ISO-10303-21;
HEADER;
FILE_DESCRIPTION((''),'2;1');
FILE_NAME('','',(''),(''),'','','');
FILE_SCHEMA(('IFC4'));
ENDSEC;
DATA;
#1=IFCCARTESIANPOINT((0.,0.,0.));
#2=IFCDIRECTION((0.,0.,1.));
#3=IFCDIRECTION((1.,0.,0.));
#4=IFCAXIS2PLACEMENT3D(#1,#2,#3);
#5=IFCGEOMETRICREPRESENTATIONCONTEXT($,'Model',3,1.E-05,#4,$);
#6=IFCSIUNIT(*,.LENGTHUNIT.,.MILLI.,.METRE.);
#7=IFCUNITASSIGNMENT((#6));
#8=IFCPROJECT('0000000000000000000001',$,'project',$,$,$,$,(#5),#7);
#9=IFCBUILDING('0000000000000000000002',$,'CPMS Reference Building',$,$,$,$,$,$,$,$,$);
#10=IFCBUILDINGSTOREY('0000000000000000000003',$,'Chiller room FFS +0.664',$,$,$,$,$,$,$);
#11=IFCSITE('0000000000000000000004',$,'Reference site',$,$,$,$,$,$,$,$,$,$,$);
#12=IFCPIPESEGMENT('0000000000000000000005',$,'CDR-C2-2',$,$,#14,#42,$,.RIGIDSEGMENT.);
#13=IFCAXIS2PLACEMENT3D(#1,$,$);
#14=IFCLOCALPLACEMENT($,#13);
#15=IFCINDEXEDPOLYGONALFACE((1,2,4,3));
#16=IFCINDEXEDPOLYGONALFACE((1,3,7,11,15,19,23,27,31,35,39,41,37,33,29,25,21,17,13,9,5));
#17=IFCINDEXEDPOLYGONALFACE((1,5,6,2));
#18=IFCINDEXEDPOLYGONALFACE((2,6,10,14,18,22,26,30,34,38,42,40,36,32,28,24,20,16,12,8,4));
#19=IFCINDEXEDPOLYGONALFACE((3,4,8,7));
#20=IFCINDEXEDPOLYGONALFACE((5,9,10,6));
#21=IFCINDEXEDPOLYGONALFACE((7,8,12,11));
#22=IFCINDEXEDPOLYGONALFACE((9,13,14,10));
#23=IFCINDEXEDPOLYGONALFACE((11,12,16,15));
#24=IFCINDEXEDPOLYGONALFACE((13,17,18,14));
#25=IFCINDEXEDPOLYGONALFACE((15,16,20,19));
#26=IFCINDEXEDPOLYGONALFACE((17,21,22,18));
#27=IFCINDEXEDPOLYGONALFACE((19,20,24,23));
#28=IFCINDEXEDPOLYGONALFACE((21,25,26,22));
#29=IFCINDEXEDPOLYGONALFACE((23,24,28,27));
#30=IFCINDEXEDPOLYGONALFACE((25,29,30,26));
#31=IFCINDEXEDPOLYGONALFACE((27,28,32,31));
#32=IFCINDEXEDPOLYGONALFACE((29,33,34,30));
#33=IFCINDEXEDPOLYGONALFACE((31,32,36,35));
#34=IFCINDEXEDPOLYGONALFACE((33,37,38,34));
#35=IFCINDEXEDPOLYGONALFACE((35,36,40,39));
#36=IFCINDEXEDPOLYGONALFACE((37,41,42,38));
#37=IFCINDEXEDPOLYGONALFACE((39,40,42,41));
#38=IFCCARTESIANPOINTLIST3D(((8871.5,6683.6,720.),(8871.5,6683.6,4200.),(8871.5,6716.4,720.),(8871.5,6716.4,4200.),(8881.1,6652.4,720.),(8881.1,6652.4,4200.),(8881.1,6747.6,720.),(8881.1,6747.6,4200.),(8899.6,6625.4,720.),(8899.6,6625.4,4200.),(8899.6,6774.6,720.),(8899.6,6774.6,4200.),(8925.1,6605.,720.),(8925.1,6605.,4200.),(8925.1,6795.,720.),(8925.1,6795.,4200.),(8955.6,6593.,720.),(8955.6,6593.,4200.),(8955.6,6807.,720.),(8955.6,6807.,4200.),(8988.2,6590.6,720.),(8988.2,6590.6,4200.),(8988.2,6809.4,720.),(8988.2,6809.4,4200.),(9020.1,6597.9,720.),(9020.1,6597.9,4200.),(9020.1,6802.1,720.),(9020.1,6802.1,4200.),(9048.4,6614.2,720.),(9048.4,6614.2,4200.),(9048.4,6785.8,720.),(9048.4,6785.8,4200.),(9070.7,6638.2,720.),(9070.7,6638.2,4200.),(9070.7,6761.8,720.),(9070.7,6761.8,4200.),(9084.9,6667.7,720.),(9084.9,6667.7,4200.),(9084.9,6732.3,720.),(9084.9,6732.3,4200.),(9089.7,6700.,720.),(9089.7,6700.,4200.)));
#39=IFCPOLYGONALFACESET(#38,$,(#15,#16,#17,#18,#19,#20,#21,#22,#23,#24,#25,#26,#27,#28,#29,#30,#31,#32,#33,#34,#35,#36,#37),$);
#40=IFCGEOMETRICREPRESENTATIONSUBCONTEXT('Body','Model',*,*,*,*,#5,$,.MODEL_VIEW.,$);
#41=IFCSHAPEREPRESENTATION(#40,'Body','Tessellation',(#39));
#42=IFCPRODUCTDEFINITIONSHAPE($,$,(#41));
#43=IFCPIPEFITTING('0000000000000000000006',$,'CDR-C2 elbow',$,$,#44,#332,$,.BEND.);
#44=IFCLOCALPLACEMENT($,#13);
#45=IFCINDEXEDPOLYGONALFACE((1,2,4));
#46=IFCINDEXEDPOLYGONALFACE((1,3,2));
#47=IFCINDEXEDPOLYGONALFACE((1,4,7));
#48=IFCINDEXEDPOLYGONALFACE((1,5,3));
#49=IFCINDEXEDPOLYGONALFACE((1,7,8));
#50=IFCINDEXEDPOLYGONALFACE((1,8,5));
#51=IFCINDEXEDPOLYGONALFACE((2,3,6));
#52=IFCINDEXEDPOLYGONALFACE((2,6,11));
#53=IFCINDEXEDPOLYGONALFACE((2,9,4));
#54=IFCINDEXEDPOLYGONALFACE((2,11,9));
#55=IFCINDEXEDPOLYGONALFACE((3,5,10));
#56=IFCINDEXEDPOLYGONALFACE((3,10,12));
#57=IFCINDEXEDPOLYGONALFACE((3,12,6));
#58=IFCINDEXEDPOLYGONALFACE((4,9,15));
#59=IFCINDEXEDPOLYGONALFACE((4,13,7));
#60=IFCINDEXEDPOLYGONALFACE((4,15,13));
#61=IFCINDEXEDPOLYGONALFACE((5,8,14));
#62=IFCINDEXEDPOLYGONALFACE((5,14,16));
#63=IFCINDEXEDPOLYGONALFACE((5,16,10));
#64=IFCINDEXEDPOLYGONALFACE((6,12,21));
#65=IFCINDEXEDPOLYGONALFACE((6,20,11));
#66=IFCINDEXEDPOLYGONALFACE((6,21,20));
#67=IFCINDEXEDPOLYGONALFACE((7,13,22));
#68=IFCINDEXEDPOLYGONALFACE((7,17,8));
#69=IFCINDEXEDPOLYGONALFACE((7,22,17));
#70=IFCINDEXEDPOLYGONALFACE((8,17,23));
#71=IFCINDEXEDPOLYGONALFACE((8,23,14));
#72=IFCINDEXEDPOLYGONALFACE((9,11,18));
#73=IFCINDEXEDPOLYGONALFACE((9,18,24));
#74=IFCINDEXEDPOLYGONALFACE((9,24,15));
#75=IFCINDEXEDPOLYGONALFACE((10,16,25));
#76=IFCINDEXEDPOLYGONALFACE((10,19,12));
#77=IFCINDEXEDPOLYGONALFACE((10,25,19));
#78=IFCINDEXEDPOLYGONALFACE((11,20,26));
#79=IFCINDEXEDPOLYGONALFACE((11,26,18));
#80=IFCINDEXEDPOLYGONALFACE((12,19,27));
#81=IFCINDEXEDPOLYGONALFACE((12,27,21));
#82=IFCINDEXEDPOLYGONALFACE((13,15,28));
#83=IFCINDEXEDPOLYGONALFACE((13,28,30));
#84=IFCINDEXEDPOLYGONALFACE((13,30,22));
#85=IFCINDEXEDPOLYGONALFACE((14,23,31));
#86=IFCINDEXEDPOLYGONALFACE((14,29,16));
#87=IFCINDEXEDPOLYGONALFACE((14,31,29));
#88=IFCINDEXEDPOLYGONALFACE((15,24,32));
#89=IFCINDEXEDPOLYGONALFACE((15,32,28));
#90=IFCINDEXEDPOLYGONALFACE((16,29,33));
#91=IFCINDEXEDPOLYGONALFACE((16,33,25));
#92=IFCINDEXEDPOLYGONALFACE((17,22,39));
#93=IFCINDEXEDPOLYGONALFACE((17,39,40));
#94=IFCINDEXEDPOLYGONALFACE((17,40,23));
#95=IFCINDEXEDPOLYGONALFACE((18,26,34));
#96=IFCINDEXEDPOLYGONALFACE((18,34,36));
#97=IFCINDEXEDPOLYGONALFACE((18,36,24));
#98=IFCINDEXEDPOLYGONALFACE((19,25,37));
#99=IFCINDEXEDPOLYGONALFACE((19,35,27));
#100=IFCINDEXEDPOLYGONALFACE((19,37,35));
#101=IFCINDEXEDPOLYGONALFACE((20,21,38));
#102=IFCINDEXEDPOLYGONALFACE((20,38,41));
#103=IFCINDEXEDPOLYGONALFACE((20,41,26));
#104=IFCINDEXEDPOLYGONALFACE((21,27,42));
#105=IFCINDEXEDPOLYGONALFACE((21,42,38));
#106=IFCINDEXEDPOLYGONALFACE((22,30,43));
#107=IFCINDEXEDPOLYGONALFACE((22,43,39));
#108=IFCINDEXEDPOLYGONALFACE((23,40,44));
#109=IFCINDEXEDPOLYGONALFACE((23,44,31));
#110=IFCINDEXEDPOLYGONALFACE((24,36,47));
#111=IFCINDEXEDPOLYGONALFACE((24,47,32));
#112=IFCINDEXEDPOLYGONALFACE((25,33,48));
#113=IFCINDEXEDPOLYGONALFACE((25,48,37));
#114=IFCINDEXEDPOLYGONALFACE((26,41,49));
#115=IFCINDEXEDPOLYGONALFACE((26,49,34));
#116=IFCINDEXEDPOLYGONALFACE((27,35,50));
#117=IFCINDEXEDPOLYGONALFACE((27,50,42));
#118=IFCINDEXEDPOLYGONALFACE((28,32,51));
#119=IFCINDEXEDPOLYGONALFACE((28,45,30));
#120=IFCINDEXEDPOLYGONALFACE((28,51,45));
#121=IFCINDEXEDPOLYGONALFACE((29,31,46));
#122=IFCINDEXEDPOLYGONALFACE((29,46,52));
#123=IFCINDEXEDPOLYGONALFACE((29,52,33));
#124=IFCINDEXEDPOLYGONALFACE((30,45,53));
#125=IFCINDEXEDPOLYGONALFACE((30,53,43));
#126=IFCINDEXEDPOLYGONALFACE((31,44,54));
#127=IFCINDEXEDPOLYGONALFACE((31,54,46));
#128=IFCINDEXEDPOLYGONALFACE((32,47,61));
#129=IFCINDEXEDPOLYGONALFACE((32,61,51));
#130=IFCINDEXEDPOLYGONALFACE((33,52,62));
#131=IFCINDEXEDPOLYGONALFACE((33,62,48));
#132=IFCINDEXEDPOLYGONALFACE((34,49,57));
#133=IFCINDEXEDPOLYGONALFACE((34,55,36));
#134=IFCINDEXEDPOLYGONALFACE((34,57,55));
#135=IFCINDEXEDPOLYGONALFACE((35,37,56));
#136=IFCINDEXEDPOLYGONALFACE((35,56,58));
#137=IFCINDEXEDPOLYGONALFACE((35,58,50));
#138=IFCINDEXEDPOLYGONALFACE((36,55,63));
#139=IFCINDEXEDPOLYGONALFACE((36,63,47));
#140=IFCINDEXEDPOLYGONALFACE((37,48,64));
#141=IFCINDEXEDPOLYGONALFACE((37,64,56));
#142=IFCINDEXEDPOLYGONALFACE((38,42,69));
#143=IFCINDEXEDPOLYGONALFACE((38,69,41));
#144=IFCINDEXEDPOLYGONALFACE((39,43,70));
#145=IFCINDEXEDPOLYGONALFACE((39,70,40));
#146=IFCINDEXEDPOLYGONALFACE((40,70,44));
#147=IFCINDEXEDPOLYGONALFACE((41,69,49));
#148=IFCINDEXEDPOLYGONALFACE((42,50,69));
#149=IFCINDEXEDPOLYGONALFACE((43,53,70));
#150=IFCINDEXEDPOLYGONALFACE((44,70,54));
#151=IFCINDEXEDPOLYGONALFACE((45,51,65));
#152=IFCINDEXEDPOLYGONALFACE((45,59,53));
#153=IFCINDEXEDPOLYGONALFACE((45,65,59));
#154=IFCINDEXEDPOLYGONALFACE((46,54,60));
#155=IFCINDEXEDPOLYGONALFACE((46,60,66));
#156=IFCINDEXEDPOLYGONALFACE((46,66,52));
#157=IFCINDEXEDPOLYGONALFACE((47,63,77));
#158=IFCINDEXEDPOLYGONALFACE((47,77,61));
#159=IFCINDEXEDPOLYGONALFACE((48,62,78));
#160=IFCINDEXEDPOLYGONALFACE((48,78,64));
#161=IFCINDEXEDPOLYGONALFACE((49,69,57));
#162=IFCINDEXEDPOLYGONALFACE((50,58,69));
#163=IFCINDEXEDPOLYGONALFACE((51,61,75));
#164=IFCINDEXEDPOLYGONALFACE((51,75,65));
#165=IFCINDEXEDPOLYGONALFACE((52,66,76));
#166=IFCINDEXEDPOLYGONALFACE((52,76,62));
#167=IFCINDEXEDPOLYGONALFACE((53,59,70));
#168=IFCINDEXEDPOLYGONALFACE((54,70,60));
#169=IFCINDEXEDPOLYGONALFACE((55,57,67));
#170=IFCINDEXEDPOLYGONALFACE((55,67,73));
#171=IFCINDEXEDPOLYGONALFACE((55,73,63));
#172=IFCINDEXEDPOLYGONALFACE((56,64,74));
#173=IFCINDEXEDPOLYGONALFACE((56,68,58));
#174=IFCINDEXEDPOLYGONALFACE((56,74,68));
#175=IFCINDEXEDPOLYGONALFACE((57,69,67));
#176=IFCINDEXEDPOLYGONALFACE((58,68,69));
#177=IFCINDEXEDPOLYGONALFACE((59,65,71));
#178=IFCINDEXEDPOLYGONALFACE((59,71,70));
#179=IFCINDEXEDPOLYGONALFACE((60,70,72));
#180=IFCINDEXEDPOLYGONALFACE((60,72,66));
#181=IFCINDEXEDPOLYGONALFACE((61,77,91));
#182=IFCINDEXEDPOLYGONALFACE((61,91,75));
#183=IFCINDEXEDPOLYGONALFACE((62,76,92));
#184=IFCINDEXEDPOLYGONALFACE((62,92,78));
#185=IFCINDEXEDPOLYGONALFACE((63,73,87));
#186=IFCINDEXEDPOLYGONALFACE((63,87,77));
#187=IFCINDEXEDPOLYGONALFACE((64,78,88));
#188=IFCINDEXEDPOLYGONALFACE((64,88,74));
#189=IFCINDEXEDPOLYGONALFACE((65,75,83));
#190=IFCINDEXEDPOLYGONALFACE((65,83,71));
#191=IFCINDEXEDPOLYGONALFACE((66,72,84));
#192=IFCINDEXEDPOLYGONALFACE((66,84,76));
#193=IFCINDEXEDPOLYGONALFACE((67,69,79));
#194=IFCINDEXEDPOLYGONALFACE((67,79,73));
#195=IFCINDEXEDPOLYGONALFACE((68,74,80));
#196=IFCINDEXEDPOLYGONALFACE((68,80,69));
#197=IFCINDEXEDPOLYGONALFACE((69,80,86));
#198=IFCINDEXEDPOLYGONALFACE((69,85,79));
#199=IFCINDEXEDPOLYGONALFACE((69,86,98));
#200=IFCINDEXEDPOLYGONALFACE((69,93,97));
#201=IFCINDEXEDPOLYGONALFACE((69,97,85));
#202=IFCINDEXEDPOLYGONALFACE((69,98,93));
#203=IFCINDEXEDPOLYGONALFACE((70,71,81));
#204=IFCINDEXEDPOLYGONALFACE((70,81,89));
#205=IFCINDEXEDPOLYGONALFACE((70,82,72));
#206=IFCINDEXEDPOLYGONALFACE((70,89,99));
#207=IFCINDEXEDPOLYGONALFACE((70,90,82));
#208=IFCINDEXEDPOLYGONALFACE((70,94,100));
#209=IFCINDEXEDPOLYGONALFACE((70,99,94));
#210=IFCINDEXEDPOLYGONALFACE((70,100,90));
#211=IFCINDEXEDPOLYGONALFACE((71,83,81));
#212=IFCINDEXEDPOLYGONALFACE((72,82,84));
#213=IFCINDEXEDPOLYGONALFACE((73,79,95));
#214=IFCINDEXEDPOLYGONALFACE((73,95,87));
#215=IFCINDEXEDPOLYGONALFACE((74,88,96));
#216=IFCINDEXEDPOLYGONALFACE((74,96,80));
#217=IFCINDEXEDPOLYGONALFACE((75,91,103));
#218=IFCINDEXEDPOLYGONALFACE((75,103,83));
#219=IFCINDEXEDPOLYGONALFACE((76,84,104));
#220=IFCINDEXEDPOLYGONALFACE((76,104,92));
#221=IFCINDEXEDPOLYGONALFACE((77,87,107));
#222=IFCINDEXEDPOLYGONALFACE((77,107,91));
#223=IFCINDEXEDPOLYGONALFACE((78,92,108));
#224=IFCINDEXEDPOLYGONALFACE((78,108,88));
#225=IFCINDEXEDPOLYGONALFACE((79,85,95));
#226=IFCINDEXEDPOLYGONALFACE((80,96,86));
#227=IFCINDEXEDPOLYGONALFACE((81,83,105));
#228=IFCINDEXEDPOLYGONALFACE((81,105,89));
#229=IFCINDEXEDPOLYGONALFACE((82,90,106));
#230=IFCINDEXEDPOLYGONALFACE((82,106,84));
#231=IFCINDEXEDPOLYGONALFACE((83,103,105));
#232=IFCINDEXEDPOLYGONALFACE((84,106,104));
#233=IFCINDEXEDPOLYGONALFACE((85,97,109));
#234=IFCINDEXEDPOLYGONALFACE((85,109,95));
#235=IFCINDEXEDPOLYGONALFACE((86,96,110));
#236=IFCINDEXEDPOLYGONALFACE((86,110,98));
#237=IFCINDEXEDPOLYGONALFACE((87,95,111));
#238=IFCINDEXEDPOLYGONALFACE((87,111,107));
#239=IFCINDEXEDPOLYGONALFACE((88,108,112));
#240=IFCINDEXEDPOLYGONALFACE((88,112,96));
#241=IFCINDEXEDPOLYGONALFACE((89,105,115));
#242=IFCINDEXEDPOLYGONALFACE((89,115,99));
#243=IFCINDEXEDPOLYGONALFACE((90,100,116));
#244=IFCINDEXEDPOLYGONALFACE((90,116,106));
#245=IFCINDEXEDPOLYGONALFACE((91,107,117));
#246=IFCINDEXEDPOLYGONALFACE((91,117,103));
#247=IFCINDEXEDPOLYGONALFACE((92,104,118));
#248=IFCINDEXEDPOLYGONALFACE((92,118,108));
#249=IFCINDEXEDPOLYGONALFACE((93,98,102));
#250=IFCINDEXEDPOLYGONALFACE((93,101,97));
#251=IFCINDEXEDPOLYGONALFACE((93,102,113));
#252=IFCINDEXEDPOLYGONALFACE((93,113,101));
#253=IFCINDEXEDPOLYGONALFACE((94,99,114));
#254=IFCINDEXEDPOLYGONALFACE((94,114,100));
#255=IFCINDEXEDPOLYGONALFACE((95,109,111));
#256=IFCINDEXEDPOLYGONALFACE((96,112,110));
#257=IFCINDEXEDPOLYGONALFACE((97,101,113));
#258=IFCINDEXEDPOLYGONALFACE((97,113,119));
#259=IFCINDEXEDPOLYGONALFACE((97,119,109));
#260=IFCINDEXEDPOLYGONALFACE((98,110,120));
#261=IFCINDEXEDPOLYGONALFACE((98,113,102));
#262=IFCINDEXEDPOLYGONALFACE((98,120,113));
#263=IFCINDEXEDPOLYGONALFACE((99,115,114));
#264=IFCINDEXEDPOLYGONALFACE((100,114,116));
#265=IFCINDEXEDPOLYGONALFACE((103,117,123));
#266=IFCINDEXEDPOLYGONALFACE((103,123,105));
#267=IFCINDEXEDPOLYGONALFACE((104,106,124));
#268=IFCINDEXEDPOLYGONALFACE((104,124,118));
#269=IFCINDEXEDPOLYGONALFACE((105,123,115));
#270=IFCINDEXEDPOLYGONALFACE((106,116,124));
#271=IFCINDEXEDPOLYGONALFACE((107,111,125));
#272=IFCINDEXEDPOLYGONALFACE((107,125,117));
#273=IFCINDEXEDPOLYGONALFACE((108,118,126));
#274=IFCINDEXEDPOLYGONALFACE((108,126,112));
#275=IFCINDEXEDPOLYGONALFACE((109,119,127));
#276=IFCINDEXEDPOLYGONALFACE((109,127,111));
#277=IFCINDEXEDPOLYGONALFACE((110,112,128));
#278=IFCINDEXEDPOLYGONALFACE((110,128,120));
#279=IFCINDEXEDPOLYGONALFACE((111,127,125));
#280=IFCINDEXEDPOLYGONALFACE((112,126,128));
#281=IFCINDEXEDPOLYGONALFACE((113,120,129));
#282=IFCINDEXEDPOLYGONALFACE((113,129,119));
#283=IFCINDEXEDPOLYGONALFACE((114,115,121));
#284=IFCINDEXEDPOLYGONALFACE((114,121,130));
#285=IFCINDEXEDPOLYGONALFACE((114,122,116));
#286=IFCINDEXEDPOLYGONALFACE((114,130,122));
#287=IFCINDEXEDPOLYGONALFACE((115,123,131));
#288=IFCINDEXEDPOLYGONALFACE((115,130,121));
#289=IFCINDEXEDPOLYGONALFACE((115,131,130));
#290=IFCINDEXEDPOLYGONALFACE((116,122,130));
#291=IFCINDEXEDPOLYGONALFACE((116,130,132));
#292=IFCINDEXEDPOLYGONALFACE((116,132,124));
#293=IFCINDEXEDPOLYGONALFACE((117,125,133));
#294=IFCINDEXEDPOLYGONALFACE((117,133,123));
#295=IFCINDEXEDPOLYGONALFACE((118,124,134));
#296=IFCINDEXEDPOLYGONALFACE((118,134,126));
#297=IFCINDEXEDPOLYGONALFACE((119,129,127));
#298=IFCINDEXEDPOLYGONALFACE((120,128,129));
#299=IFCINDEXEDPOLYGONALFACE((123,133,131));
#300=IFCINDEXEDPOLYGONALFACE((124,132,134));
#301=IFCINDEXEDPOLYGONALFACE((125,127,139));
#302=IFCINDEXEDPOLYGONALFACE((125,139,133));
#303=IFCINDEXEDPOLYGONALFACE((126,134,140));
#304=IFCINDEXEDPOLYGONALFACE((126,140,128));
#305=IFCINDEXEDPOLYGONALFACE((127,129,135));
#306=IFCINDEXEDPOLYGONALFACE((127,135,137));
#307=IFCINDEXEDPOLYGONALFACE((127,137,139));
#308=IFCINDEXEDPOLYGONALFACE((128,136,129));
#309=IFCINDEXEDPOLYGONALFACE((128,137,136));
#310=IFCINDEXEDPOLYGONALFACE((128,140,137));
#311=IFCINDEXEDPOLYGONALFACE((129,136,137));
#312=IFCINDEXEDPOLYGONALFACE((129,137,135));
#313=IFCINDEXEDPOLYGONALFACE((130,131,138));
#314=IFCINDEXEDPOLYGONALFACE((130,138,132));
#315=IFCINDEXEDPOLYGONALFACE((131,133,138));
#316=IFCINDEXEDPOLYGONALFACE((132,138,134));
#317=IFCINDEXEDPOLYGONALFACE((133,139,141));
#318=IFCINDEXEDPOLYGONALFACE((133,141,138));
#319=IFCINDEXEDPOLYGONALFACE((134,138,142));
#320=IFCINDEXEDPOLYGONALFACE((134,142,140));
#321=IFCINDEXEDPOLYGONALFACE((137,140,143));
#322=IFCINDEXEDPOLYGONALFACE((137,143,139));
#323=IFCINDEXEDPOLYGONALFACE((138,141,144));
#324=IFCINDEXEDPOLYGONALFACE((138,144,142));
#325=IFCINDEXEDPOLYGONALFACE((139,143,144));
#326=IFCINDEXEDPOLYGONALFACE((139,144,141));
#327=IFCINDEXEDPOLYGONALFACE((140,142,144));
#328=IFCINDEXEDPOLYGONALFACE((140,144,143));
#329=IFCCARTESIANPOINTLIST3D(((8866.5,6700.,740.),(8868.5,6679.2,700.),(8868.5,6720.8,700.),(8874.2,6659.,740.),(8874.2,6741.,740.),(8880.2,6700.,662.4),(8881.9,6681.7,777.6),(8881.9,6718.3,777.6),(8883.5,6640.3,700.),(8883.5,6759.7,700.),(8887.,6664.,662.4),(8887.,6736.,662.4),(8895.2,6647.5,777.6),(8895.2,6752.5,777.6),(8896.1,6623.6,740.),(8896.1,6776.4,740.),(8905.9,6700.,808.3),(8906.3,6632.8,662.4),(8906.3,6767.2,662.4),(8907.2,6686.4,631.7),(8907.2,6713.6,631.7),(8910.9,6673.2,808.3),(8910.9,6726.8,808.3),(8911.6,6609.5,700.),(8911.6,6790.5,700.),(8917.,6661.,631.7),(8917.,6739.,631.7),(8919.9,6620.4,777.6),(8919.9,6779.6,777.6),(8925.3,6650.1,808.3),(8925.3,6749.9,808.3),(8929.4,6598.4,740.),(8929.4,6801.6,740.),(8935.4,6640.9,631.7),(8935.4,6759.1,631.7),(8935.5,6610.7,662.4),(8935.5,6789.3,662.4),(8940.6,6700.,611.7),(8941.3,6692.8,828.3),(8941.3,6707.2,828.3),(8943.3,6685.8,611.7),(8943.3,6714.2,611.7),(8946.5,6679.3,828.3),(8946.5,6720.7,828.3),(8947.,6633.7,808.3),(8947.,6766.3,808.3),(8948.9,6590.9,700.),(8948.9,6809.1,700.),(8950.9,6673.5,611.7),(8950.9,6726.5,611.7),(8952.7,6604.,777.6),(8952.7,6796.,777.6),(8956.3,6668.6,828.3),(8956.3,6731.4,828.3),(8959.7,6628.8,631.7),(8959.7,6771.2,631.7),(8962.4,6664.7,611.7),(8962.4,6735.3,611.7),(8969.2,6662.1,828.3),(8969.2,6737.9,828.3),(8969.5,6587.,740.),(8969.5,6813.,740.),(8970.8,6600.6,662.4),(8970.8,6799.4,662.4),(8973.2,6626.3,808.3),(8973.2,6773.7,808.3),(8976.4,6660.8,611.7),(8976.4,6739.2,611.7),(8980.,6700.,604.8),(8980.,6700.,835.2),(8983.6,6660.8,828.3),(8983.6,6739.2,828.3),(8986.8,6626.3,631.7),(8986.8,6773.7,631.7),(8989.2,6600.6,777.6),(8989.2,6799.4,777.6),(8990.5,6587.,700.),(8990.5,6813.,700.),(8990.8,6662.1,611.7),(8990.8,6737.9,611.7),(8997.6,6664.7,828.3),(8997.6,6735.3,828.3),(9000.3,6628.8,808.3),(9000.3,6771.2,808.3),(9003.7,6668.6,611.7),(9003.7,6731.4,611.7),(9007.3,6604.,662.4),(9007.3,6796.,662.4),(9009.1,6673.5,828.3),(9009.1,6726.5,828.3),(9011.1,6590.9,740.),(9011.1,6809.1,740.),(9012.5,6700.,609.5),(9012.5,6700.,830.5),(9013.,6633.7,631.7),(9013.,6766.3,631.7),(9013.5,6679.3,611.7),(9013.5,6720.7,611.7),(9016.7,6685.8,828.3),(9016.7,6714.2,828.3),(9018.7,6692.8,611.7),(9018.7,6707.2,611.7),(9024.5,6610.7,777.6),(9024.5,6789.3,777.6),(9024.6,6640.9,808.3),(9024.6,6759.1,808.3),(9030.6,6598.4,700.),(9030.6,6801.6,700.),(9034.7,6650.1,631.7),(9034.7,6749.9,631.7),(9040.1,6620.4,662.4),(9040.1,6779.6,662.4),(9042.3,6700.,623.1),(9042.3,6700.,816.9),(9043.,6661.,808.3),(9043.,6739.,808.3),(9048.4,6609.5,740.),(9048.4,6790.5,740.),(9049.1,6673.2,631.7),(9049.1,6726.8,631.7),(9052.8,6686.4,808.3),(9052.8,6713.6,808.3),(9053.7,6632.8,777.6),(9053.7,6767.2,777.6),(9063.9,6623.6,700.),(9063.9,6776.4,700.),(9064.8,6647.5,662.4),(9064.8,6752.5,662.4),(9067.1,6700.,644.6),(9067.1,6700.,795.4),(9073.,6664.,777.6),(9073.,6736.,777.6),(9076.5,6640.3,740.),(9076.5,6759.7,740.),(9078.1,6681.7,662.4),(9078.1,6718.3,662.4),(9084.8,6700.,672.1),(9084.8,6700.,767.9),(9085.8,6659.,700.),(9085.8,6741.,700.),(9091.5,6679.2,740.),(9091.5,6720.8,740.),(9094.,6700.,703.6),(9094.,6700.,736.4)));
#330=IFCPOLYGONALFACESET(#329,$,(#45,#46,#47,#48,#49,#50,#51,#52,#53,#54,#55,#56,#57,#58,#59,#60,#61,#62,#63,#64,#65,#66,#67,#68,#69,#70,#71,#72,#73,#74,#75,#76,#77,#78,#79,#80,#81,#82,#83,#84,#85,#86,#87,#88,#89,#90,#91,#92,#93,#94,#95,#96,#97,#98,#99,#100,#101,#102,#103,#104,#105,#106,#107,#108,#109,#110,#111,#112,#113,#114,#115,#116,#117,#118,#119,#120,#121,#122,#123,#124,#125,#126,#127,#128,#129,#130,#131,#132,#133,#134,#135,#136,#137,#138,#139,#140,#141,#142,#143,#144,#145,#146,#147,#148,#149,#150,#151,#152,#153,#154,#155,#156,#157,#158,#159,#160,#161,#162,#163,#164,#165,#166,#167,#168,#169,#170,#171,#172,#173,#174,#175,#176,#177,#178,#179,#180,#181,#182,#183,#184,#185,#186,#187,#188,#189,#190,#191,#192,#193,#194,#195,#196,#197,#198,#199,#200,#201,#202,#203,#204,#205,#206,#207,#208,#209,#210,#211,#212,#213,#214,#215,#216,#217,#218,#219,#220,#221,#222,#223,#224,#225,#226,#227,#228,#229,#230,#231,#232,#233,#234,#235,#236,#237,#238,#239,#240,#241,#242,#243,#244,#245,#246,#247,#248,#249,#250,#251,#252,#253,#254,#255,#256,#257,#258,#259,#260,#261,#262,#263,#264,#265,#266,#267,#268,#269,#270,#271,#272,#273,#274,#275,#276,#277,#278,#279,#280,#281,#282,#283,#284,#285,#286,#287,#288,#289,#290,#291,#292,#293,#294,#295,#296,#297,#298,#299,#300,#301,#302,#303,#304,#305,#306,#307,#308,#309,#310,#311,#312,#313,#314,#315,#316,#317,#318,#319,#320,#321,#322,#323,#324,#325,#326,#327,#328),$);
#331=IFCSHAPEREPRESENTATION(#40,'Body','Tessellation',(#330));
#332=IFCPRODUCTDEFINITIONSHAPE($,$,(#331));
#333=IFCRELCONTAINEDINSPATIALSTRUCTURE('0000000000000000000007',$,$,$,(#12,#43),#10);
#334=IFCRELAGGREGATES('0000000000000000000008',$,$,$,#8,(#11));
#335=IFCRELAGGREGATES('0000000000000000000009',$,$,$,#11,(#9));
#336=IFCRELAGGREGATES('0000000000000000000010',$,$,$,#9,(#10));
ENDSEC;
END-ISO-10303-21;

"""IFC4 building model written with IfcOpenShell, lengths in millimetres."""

from ifc_helpers import new_model, entity, si_unit, frame, origin_with_axes, origin_2d, place, context, subcontext, project, spatial, circle_curve, outline, extrude, element, save


model = new_model("IFC4")

# Units and contexts
model_context = context("Model", 3, precision=1e-05, world=origin_with_axes())
body_context = subcontext(model_context, "Body", "Model", "MODEL_VIEW")
ifc_project = project(units=[si_unit("LENGTHUNIT", "METRE", prefix="MILLI")], contexts=[model_context])

# Site, building, storey
site = spatial("IfcSite", under=ifc_project, Name="Reference site")
building = spatial("IfcBuilding", under=site, Name="CPMS Reference Building")
storey = spatial("IfcBuildingStorey", under=building, Name="Chiller room FFS +0.664")

# Pipe segment
pipe_segment_1_placement = place(None, origin_with_axes())
element("IfcPipeSegment", 1, at=pipe_segment_1_placement, inside=storey, Name="CDR-C2-2", PredefinedType="RIGIDSEGMENT", context=body_context, shape_type="SweptSolid", body=[
    extrude(outline(circle_curve(origin_2d(), 109.7)), frame((8980.0, 6700.0, 720.0), z_axis=(0.0, 0.0, 1.0), x_axis=(1.0, 0.0, 0.0)), (0.0, 0.0, 1.0), 3480.0),
])

# Pipe fitting
pipe_fitting_1_placement = place(None, origin_with_axes())
element("IfcPipeFitting", 2, at=pipe_fitting_1_placement, inside=storey, Name="CDR-C2 elbow", PredefinedType="BEND", context=body_context, shape_type="CSG", body=[
    entity("IfcSphere", entity("IfcAxis2Placement3D", entity("IfcCartesianPoint", [8980.0, 6700.0, 720.0]), entity("IfcDirection", [0.0, 0.0, 1.0]), entity("IfcDirection", [1.0, 0.0, 0.0])), 115.2),
])

save(model, "model.ifc")
